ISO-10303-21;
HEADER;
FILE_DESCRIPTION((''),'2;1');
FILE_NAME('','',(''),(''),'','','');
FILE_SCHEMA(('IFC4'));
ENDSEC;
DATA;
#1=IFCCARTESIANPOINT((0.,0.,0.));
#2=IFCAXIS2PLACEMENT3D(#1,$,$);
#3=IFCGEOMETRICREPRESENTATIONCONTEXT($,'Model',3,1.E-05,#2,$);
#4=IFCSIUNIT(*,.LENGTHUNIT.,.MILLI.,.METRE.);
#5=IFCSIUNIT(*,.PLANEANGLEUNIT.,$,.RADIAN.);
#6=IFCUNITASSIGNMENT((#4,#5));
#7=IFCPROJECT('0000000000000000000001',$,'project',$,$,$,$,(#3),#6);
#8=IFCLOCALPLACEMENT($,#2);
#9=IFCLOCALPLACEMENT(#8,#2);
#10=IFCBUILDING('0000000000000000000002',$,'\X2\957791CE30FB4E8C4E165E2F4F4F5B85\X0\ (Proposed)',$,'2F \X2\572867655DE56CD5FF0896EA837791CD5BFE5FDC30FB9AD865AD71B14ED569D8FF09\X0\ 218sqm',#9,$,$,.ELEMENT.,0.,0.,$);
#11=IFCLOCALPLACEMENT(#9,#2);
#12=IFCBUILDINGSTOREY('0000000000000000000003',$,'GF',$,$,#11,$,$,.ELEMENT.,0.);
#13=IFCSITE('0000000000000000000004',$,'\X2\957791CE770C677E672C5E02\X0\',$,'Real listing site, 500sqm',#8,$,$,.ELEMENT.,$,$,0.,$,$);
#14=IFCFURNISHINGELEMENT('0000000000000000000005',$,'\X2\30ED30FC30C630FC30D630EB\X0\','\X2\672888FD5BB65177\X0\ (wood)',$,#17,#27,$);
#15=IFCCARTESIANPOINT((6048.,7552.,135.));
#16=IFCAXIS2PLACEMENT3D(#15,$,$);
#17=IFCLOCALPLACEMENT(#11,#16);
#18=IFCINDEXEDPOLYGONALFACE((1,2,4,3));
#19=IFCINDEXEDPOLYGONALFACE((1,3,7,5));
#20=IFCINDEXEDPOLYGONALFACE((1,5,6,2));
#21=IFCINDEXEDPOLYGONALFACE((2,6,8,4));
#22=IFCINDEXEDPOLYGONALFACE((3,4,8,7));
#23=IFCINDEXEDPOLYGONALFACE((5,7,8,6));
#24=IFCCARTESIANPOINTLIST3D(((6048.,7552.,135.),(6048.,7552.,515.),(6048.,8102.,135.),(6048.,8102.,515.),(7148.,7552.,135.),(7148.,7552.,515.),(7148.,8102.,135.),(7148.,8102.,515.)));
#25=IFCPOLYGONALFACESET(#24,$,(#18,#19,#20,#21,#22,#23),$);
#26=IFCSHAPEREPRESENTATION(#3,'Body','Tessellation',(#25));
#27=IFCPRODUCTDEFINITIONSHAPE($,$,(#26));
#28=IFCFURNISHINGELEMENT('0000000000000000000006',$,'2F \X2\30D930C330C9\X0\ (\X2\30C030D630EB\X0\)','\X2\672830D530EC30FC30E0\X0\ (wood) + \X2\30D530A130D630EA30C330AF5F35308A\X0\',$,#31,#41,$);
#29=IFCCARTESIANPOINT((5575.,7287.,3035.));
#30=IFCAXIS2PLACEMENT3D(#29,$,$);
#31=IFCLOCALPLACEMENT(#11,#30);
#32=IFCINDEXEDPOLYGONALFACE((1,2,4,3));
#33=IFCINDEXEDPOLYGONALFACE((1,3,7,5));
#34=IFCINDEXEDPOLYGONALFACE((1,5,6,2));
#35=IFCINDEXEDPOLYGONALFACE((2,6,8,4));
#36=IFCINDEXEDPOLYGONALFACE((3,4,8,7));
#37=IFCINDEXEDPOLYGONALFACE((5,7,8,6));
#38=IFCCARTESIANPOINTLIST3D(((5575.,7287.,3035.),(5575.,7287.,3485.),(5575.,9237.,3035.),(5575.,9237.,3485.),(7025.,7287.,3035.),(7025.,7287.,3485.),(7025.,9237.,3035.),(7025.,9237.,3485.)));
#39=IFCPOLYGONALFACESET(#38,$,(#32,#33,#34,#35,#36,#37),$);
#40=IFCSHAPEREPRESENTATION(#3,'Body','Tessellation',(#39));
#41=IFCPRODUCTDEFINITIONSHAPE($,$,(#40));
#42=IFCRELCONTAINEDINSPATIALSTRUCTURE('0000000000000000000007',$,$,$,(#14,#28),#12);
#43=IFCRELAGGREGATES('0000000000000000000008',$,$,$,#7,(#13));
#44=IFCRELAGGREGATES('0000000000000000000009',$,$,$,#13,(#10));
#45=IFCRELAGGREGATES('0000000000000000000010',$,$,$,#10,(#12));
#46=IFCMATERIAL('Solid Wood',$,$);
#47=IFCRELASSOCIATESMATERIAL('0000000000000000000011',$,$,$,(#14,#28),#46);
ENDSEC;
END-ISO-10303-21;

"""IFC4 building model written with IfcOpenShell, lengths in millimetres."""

from ifc_helpers import new_model, si_unit, frame, frame_2d, origin, place, context, project, spatial, rectangle, extrude, material, element, save


model = new_model("IFC4")

# Units and contexts
model_context = context("Model", 3, precision=1e-05, world=origin())
ifc_project = project(units=[si_unit("LENGTHUNIT", "METRE", prefix="MILLI"), si_unit("PLANEANGLEUNIT", "RADIAN")], contexts=[model_context])

# Site, building, storey
site_placement = place(None, origin())
site = spatial("IfcSite", under=ifc_project, at=site_placement, Name="長野県松本市", ObjectType="Real listing site, 500sqm", CompositionType="ELEMENT", RefElevation=0.0)
building_placement = place(site_placement, origin())
building = spatial("IfcBuilding", under=site, at=building_placement, Name="長野・二世帯住宅 (Proposed)", ObjectType="2F 在来工法（雪荷重対応・高断熱仕様） 218sqm", CompositionType="ELEMENT", ElevationOfRefHeight=0.0, ElevationOfTerrain=0.0)
storey_placement = place(building_placement, origin())
storey = spatial("IfcBuildingStorey", under=building, at=storey_placement, Name="GF", CompositionType="ELEMENT", Elevation=0.0)

# Shared definitions
ifc_material_1 = material(Name="Solid Wood")

# Furnishing elements
furnishing_1_placement = place(storey_placement, frame((6048.0, 7552.0, 135.0)))
element("IfcFurnishingElement", 1, at=furnishing_1_placement, inside=storey, material=ifc_material_1, Name="ローテーブル", Description="木製家具 (wood)", context=model_context, shape_type="SweptSolid", body=[
    extrude(rectangle(XDim=1100.0, YDim=550.0, at=frame_2d((550.0, 275.0))), frame((6048.0, 7552.0, 135.0)), (0.0, 0.0, 1.0), 380.0),
])
furnishing_2_placement = place(storey_placement, frame((5575.0, 7287.0, 3035.0)))
element("IfcFurnishingElement", 2, at=furnishing_2_placement, inside=storey, material=ifc_material_1, Name="2F ベッド (ダブル)", Description="木フレーム (wood) + ファブリック張り", context=model_context, shape_type="SweptSolid", body=[
    extrude(rectangle(XDim=1450.0, YDim=1950.0, at=frame_2d((725.0, 975.0))), frame((5575.0, 7287.0, 3035.0)), (0.0, 0.0, 1.0), 450.0),
])

save(model, "model.ifc")
